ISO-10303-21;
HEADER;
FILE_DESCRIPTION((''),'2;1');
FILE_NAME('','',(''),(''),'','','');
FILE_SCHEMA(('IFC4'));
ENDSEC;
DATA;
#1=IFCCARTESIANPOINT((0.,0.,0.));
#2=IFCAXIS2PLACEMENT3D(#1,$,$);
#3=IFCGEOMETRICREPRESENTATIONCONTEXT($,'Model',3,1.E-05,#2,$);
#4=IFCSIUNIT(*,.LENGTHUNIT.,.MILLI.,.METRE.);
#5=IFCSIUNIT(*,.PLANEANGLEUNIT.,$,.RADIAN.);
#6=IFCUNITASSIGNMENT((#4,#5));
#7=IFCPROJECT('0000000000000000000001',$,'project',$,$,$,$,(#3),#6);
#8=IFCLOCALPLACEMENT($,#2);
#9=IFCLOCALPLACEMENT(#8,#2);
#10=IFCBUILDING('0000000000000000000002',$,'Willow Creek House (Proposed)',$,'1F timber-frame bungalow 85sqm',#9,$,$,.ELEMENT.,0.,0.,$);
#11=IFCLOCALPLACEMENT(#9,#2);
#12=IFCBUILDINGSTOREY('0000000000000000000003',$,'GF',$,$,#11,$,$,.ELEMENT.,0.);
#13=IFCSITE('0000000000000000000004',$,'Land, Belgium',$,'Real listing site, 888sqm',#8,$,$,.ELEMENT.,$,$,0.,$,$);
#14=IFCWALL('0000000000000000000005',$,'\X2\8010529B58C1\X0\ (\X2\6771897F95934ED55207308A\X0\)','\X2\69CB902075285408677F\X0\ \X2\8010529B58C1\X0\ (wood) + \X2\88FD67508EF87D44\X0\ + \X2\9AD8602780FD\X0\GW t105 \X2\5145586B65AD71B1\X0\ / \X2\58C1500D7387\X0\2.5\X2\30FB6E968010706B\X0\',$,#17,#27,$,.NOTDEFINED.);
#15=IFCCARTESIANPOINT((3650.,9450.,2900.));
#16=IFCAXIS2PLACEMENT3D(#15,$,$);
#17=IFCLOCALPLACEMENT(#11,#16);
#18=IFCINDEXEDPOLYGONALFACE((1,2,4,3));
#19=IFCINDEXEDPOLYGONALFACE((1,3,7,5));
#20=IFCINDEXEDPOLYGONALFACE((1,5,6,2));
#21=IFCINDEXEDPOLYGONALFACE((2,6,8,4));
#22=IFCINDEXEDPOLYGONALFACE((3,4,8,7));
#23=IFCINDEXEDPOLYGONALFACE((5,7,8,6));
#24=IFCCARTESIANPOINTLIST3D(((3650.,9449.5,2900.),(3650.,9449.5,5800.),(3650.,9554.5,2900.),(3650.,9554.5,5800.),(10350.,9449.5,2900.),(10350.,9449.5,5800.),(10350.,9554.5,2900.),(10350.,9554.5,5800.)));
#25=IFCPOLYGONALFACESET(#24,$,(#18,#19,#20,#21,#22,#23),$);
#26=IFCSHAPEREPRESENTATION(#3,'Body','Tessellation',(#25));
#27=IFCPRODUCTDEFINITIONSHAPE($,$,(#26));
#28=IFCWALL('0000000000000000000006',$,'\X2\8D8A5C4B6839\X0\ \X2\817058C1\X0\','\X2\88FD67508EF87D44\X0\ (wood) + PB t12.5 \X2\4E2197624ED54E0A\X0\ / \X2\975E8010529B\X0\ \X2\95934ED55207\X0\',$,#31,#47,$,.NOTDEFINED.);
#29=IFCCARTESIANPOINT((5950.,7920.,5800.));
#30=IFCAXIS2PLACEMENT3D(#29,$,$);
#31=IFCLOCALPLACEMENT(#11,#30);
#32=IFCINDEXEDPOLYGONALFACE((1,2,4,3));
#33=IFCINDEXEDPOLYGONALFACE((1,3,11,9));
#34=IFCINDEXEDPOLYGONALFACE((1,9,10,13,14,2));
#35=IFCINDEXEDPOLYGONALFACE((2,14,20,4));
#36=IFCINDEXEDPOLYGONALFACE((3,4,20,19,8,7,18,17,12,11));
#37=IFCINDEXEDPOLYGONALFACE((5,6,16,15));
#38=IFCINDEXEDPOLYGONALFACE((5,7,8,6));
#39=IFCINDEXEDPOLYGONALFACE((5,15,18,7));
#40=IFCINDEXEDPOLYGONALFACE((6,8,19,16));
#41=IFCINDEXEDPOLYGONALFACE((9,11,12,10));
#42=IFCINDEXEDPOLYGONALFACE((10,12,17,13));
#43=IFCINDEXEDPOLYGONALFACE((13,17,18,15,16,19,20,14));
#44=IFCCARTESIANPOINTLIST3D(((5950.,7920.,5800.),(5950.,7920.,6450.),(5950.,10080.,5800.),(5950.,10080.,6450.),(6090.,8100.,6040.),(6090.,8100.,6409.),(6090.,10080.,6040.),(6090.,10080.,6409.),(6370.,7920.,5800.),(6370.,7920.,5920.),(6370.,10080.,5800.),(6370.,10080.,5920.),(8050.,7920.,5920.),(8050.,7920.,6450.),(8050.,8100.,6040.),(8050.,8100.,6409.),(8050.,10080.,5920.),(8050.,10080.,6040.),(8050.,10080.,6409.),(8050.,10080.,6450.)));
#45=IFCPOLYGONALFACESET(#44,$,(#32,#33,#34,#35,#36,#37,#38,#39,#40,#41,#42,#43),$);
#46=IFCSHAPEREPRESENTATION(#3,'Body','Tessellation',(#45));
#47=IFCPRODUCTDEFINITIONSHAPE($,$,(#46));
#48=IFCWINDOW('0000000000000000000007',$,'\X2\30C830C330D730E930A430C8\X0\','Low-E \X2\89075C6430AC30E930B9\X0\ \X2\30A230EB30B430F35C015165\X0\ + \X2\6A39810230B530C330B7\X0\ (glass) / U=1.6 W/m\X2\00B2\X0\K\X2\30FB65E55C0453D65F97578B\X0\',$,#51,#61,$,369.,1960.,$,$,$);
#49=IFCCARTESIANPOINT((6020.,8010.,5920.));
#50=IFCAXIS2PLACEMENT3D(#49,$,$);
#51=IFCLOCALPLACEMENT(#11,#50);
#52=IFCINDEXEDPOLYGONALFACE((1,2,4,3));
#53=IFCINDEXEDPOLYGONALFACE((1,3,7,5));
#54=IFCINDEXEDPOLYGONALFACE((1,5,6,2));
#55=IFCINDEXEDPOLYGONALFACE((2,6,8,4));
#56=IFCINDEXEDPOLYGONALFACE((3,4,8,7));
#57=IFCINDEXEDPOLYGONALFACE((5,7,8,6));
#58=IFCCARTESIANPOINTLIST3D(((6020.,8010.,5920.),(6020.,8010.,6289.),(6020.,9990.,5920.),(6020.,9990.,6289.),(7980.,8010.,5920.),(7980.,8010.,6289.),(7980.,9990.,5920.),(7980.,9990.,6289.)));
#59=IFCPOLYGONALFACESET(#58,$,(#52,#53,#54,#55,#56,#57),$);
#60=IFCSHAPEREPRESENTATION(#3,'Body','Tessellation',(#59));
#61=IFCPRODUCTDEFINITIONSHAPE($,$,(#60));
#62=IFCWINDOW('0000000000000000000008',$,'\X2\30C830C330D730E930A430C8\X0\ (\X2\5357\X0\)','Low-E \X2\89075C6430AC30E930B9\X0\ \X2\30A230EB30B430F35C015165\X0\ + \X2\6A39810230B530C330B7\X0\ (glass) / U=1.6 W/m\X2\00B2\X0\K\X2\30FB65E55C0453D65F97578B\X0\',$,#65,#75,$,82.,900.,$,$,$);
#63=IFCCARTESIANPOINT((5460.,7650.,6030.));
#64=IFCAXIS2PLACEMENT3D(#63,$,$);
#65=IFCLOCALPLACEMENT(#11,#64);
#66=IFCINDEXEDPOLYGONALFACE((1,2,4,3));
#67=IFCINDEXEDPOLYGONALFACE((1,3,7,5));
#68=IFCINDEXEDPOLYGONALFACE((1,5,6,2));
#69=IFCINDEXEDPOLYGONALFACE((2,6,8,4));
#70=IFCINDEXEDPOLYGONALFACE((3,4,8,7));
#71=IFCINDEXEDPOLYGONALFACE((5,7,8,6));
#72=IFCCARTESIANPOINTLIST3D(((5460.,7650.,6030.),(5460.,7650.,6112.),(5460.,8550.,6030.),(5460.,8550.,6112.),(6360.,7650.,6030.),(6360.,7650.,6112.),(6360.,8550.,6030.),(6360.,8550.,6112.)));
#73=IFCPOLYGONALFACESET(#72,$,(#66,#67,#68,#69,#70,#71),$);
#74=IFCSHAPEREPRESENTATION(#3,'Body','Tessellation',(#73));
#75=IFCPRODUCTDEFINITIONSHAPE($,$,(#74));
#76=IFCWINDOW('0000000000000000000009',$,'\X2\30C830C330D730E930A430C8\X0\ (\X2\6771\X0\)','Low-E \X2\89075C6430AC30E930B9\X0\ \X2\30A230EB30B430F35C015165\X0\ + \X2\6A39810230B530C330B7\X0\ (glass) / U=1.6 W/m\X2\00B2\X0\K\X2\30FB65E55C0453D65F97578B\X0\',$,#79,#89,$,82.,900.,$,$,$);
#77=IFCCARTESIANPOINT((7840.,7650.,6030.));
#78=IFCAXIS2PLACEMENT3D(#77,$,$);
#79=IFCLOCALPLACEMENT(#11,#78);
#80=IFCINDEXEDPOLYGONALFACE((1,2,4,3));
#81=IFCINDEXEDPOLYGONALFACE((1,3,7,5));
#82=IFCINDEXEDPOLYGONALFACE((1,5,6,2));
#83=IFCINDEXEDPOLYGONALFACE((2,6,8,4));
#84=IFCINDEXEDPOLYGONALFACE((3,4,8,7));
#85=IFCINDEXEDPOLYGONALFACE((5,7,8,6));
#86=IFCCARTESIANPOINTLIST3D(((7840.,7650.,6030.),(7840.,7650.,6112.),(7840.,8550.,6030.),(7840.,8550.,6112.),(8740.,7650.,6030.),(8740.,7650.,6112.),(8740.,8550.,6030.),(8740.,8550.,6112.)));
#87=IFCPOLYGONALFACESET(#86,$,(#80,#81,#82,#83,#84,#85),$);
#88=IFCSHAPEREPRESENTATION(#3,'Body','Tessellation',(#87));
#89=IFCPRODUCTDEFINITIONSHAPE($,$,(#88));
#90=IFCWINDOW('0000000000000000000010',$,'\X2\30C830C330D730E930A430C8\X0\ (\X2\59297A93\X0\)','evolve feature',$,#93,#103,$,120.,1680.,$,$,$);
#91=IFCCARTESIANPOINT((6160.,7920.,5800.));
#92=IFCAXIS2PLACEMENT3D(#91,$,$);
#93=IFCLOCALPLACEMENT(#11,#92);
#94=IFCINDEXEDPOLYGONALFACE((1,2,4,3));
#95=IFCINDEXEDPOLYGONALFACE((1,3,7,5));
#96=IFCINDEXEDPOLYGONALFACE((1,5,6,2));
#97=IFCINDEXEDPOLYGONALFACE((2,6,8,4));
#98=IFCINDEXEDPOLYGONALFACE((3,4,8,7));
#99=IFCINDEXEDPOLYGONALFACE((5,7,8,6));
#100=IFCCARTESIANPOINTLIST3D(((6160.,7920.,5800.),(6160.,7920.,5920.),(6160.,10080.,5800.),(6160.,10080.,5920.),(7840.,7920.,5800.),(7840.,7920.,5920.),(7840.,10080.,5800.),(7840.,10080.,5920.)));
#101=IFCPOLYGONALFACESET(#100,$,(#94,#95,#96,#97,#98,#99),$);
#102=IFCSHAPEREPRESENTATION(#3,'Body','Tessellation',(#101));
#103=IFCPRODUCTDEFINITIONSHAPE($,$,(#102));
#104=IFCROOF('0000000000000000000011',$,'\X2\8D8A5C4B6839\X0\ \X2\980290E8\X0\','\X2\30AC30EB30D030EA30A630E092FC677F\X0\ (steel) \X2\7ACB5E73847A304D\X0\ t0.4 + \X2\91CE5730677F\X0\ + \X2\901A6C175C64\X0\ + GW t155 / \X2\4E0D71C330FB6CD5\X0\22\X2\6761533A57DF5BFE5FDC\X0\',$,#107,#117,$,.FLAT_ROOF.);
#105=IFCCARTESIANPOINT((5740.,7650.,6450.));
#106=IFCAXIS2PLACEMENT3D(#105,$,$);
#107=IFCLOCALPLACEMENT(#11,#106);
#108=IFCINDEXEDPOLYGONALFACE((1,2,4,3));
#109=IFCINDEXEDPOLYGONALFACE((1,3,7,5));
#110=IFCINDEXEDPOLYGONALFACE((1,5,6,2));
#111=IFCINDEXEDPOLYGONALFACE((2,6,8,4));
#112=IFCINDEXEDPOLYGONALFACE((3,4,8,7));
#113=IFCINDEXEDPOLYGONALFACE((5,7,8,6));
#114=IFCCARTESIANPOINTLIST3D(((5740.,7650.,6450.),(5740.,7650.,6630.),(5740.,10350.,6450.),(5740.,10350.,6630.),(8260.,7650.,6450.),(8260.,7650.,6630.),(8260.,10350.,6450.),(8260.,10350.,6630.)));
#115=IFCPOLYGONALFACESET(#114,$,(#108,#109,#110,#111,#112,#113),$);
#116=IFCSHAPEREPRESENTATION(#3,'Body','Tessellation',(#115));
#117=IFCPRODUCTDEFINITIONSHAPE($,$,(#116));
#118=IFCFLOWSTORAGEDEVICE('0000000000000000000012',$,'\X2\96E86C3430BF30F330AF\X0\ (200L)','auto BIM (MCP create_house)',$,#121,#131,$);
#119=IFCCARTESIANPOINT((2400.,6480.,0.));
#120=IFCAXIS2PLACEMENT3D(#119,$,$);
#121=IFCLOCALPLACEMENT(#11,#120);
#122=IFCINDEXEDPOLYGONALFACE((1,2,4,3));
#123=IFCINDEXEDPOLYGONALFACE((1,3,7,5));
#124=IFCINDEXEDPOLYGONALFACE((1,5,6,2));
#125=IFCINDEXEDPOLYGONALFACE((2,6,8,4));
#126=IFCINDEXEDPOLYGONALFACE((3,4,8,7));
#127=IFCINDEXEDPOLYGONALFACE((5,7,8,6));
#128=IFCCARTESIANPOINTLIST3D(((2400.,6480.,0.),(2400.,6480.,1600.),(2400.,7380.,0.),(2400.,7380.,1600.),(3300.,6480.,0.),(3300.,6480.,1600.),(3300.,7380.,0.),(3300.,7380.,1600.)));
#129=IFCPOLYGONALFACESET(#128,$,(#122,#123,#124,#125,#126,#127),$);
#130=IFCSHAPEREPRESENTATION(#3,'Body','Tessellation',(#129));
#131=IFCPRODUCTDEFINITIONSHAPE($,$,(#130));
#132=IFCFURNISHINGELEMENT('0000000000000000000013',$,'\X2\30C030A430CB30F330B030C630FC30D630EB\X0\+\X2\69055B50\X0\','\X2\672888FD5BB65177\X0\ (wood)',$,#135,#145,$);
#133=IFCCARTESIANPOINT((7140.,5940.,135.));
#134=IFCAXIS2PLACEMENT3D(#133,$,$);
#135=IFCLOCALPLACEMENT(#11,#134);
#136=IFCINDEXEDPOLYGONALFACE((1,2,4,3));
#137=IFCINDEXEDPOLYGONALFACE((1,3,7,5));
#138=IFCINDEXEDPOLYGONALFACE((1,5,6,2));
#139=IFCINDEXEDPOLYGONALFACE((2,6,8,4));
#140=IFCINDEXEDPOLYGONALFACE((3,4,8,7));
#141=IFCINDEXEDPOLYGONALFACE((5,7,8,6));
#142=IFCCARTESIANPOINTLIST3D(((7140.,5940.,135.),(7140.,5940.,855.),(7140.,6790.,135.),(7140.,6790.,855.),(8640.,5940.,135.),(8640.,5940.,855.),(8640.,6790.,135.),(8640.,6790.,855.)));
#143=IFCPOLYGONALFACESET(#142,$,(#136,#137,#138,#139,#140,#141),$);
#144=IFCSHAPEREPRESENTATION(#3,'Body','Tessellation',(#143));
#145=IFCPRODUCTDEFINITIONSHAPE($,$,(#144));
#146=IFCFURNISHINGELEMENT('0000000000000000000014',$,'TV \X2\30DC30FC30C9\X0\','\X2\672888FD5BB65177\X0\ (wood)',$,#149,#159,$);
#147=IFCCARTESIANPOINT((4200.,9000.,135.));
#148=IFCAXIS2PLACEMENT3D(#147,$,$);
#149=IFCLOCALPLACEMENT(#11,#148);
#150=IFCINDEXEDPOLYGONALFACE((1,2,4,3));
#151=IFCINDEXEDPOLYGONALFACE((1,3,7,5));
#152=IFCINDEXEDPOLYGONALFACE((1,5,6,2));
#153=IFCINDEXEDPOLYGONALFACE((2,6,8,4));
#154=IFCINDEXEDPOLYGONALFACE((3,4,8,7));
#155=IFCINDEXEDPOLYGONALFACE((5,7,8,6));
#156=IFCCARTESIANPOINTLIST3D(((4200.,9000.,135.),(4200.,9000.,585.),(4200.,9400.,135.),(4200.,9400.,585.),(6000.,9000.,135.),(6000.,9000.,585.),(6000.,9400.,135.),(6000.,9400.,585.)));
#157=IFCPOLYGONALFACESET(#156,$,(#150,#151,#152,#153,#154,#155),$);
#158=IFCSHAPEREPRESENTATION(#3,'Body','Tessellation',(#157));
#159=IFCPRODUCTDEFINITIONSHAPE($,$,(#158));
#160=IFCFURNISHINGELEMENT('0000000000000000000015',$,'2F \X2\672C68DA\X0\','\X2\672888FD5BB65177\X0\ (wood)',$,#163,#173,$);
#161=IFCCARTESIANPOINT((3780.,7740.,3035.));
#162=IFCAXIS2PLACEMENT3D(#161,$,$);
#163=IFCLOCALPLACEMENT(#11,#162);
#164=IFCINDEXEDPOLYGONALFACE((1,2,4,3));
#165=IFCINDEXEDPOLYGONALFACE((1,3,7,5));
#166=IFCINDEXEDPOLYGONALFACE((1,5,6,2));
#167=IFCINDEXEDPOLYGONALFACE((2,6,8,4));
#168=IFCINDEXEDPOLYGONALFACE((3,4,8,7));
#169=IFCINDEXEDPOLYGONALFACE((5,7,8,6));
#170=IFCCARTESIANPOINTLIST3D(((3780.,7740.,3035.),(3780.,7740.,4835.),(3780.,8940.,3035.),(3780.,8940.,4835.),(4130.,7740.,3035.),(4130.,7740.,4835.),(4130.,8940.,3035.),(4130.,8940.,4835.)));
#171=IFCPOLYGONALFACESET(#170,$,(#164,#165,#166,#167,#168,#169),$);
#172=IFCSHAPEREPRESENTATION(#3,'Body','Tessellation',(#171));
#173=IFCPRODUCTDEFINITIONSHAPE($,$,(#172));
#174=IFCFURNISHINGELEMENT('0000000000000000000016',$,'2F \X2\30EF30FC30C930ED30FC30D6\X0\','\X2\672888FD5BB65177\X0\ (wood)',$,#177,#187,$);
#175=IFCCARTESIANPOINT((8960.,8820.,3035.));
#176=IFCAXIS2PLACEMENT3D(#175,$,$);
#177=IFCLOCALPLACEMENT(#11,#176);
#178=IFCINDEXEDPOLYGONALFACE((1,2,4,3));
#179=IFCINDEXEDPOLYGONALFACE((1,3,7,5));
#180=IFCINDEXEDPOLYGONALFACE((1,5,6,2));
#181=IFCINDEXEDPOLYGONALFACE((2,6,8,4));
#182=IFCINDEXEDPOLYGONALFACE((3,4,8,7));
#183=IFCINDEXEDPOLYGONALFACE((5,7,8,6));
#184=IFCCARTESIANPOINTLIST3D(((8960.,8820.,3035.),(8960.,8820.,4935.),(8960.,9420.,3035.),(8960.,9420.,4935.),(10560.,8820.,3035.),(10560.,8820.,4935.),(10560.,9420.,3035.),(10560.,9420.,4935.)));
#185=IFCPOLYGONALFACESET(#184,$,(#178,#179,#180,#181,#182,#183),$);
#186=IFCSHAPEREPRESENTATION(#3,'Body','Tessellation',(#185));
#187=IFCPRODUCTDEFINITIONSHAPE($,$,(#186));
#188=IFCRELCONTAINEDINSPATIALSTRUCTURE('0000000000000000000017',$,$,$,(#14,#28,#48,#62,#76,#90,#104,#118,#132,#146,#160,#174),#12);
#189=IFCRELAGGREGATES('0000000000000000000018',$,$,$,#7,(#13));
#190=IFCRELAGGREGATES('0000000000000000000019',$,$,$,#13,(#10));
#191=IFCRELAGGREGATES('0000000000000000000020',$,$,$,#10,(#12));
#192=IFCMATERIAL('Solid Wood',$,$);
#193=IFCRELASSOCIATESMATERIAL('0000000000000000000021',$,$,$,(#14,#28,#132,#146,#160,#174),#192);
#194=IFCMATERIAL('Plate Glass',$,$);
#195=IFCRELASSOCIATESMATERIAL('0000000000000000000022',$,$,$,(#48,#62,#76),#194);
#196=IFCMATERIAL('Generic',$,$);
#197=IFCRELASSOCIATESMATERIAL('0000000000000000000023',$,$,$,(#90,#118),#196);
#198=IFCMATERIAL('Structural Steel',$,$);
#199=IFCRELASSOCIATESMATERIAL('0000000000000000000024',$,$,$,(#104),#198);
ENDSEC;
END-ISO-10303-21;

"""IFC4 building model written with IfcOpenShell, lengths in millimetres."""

from ifc_helpers import new_model, si_unit, frame, frame_2d, origin, place, context, project, spatial, rectangle, extrude, material, element, fill, save


model = new_model("IFC4")

# Units and contexts
model_context = context("Model", 3, precision=1e-05, world=origin())
ifc_project = project(units=[si_unit("LENGTHUNIT", "METRE", prefix="MILLI"), si_unit("PLANEANGLEUNIT", "RADIAN")], contexts=[model_context])

# Site, building, storey
site_placement = place(None, origin())
site = spatial("IfcSite", under=ifc_project, at=site_placement, Name="Land, Belgium", ObjectType="Real listing site, 888sqm", CompositionType="ELEMENT", RefElevation=0.0)
building_placement = place(site_placement, origin())
building = spatial("IfcBuilding", under=site, at=building_placement, Name="Willow Creek House (Proposed)", ObjectType="1F timber-frame bungalow 85sqm", CompositionType="ELEMENT", ElevationOfRefHeight=0.0, ElevationOfTerrain=0.0)
storey_placement = place(building_placement, origin())
storey = spatial("IfcBuildingStorey", under=building, at=storey_placement, Name="GF", CompositionType="ELEMENT", Elevation=0.0)

# Wall
ifc_material_1 = material(Name="Solid Wood")
wall_1_placement = place(storey_placement, frame((3650.0, 9450.0, 2900.0)))
element("IfcWall", 1, at=wall_1_placement, inside=storey, material=ifc_material_1, Name="耐力壁 (東西間仕切り)", Description="構造用合板 耐力壁 (wood) + 製材軸組 + 高性能GW t105 充填断熱 / 壁倍率2.5・準耐火", PredefinedType="NOTDEFINED", context=model_context, shape_type="SweptSolid", body=[
    extrude(rectangle(XDim=6700.0, YDim=105.0, at=frame_2d((3350.0, 52.0))), frame((3650.0, 9450.0, 2900.0)), (0.0, 0.0, 1.0), 2900.0),
])

# Wall, openings, windows
wall_2_placement = place(storey_placement, frame((5950.0, 7920.0, 5800.0)))
wall_2 = element("IfcWall", 2, at=wall_2_placement, inside=storey, material=ifc_material_1, Name="越屋根 腰壁", Description="製材軸組 (wood) + PB t12.5 両面仕上 / 非耐力 間仕切", PredefinedType="NOTDEFINED", context=model_context, shape_type="SweptSolid", body=[
    extrude(rectangle(XDim=2100.0, YDim=2160.0, at=frame_2d((1050.0, 1080.0))), frame((5950.0, 7920.0, 5800.0)), (0.0, 0.0, 1.0), 650.0),
])
opening_1_placement = place(storey_placement, frame((6020.0, 8010.0, 5920.0)))
opening_1 = element("IfcOpeningElement", 3, at=opening_1_placement, cuts=wall_2, PredefinedType="NOTDEFINED", context=model_context, shape_type="SweptSolid", body=[
    extrude(rectangle(XDim=1960.0, YDim=1980.0, at=frame_2d((980.0, 990.0))), frame((6020.0, 8010.0, 5920.0)), (0.0, 0.0, 1.0), 369.0),
])
opening_2_placement = place(storey_placement, frame((5460.0, 7650.0, 6030.0)))
opening_2 = element("IfcOpeningElement", 4, at=opening_2_placement, cuts=wall_2, PredefinedType="NOTDEFINED", context=model_context, shape_type="SweptSolid", body=[
    extrude(rectangle(XDim=900.0, YDim=900.0, at=frame_2d((450.0, 450.0))), frame((5460.0, 7650.0, 6030.0)), (0.0, 0.0, 1.0), 82.0),
])
opening_3_placement = place(storey_placement, frame((7840.0, 7650.0, 6030.0)))
opening_3 = element("IfcOpeningElement", 5, at=opening_3_placement, cuts=wall_2, PredefinedType="NOTDEFINED", context=model_context, shape_type="SweptSolid", body=[
    extrude(rectangle(XDim=900.0, YDim=900.0, at=frame_2d((450.0, 450.0))), frame((7840.0, 7650.0, 6030.0)), (0.0, 0.0, 1.0), 82.0),
])
opening_4_placement = place(storey_placement, frame((6160.0, 7920.0, 5800.0)))
opening_4 = element("IfcOpeningElement", 6, at=opening_4_placement, cuts=wall_2, PredefinedType="NOTDEFINED", context=model_context, shape_type="SweptSolid", body=[
    extrude(rectangle(XDim=1680.0, YDim=2160.0, at=frame_2d((840.0, 1080.0))), frame((6160.0, 7920.0, 5800.0)), (0.0, 0.0, 1.0), 120.0),
])
ifc_material_2 = material(Name="Plate Glass")
window_1_placement = place(storey_placement, frame((6020.0, 8010.0, 5920.0)))
window_1 = element("IfcWindow", 7, at=window_1_placement, inside=storey, material=ifc_material_2, Name="トップライト", Description="Low-E 複層ガラス アルゴン封入 + 樹脂サッシ (glass) / U=1.6 W/m²K・日射取得型", OverallHeight=369.0, OverallWidth=1960.0, context=model_context, shape_type="SweptSolid", body=[
    extrude(rectangle(XDim=1960.0, YDim=1980.0, at=frame_2d((980.0, 990.0))), frame((6020.0, 8010.0, 5920.0)), (0.0, 0.0, 1.0), 369.0),
])
fill(opening_1, window_1)
window_2_placement = place(storey_placement, frame((5460.0, 7650.0, 6030.0)))
window_2 = element("IfcWindow", 8, at=window_2_placement, inside=storey, material=ifc_material_2, Name="トップライト (南)", Description="Low-E 複層ガラス アルゴン封入 + 樹脂サッシ (glass) / U=1.6 W/m²K・日射取得型", OverallHeight=82.0, OverallWidth=900.0, context=model_context, shape_type="SweptSolid", body=[
    extrude(rectangle(XDim=900.0, YDim=900.0, at=frame_2d((450.0, 450.0))), frame((5460.0, 7650.0, 6030.0)), (0.0, 0.0, 1.0), 82.0),
])
fill(opening_2, window_2)
window_3_placement = place(storey_placement, frame((7840.0, 7650.0, 6030.0)))
window_3 = element("IfcWindow", 9, at=window_3_placement, inside=storey, material=ifc_material_2, Name="トップライト (東)", Description="Low-E 複層ガラス アルゴン封入 + 樹脂サッシ (glass) / U=1.6 W/m²K・日射取得型", OverallHeight=82.0, OverallWidth=900.0, context=model_context, shape_type="SweptSolid", body=[
    extrude(rectangle(XDim=900.0, YDim=900.0, at=frame_2d((450.0, 450.0))), frame((7840.0, 7650.0, 6030.0)), (0.0, 0.0, 1.0), 82.0),
])
fill(opening_3, window_3)
ifc_material_3 = material(Name="Generic")
window_4_placement = place(storey_placement, frame((6160.0, 7920.0, 5800.0)))
window_4 = element("IfcWindow", 10, at=window_4_placement, inside=storey, material=ifc_material_3, Name="トップライト (天窓)", Description="evolve feature", OverallHeight=120.0, OverallWidth=1680.0, context=model_context, shape_type="SweptSolid", body=[
    extrude(rectangle(XDim=1680.0, YDim=2160.0, at=frame_2d((840.0, 1080.0))), frame((6160.0, 7920.0, 5800.0)), (0.0, 0.0, 1.0), 120.0),
])
fill(opening_4, window_4)

# Roof
ifc_material_4 = material(Name="Structural Steel")
roof_placement = place(storey_placement, frame((5740.0, 7650.0, 6450.0)))
element("IfcRoof", 11, at=roof_placement, inside=storey, material=ifc_material_4, Name="越屋根 頂部", Description="ガルバリウム鋼板 (steel) 立平葺き t0.4 + 野地板 + 通気層 + GW t155 / 不燃・法22条区域対応", PredefinedType="FLAT_ROOF", context=model_context, shape_type="SweptSolid", body=[
    extrude(rectangle(XDim=2520.0, YDim=2700.0, at=frame_2d((1260.0, 1350.0))), frame((5740.0, 7650.0, 6450.0)), (0.0, 0.0, 1.0), 180.0),
])

# Flow storage device
flow_storage_device_placement = place(storey_placement, frame((2400.0, 6480.0, 0.0)))
element("IfcFlowStorageDevice", 12, at=flow_storage_device_placement, inside=storey, material=ifc_material_3, Name="雨水タンク (200L)", Description="auto BIM (MCP create_house)", context=model_context, shape_type="SweptSolid", body=[
    extrude(rectangle(XDim=900.0, YDim=900.0, at=frame_2d((450.0, 450.0))), frame((2400.0, 6480.0, 0.0)), (0.0, 0.0, 1.0), 1600.0),
])

# Furnishing elements
furnishing_1_placement = place(storey_placement, frame((7140.0, 5940.0, 135.0)))
element("IfcFurnishingElement", 13, at=furnishing_1_placement, inside=storey, material=ifc_material_1, Name="ダイニングテーブル+椅子", Description="木製家具 (wood)", context=model_context, shape_type="SweptSolid", body=[
    extrude(rectangle(XDim=1500.0, YDim=850.0, at=frame_2d((750.0, 425.0))), frame((7140.0, 5940.0, 135.0)), (0.0, 0.0, 1.0), 720.0),
])
furnishing_2_placement = place(storey_placement, frame((4200.0, 9000.0, 135.0)))
element("IfcFurnishingElement", 14, at=furnishing_2_placement, inside=storey, material=ifc_material_1, Name="TV ボード", Description="木製家具 (wood)", context=model_context, shape_type="SweptSolid", body=[
    extrude(rectangle(XDim=1800.0, YDim=400.0, at=frame_2d((900.0, 200.0))), frame((4200.0, 9000.0, 135.0)), (0.0, 0.0, 1.0), 450.0),
])
furnishing_3_placement = place(storey_placement, frame((3780.0, 7740.0, 3035.0)))
element("IfcFurnishingElement", 15, at=furnishing_3_placement, inside=storey, material=ifc_material_1, Name="2F 本棚", Description="木製家具 (wood)", context=model_context, shape_type="SweptSolid", body=[
    extrude(rectangle(XDim=350.0, YDim=1200.0, at=frame_2d((175.0, 600.0))), frame((3780.0, 7740.0, 3035.0)), (0.0, 0.0, 1.0), 1800.0),
])
furnishing_4_placement = place(storey_placement, frame((8960.0, 8820.0, 3035.0)))
element("IfcFurnishingElement", 16, at=furnishing_4_placement, inside=storey, material=ifc_material_1, Name="2F ワードローブ", Description="木製家具 (wood)", context=model_context, shape_type="SweptSolid", body=[
    extrude(rectangle(XDim=1600.0, YDim=600.0, at=frame_2d((800.0, 300.0))), frame((8960.0, 8820.0, 3035.0)), (0.0, 0.0, 1.0), 1900.0),
])

save(model, "model.ifc")
